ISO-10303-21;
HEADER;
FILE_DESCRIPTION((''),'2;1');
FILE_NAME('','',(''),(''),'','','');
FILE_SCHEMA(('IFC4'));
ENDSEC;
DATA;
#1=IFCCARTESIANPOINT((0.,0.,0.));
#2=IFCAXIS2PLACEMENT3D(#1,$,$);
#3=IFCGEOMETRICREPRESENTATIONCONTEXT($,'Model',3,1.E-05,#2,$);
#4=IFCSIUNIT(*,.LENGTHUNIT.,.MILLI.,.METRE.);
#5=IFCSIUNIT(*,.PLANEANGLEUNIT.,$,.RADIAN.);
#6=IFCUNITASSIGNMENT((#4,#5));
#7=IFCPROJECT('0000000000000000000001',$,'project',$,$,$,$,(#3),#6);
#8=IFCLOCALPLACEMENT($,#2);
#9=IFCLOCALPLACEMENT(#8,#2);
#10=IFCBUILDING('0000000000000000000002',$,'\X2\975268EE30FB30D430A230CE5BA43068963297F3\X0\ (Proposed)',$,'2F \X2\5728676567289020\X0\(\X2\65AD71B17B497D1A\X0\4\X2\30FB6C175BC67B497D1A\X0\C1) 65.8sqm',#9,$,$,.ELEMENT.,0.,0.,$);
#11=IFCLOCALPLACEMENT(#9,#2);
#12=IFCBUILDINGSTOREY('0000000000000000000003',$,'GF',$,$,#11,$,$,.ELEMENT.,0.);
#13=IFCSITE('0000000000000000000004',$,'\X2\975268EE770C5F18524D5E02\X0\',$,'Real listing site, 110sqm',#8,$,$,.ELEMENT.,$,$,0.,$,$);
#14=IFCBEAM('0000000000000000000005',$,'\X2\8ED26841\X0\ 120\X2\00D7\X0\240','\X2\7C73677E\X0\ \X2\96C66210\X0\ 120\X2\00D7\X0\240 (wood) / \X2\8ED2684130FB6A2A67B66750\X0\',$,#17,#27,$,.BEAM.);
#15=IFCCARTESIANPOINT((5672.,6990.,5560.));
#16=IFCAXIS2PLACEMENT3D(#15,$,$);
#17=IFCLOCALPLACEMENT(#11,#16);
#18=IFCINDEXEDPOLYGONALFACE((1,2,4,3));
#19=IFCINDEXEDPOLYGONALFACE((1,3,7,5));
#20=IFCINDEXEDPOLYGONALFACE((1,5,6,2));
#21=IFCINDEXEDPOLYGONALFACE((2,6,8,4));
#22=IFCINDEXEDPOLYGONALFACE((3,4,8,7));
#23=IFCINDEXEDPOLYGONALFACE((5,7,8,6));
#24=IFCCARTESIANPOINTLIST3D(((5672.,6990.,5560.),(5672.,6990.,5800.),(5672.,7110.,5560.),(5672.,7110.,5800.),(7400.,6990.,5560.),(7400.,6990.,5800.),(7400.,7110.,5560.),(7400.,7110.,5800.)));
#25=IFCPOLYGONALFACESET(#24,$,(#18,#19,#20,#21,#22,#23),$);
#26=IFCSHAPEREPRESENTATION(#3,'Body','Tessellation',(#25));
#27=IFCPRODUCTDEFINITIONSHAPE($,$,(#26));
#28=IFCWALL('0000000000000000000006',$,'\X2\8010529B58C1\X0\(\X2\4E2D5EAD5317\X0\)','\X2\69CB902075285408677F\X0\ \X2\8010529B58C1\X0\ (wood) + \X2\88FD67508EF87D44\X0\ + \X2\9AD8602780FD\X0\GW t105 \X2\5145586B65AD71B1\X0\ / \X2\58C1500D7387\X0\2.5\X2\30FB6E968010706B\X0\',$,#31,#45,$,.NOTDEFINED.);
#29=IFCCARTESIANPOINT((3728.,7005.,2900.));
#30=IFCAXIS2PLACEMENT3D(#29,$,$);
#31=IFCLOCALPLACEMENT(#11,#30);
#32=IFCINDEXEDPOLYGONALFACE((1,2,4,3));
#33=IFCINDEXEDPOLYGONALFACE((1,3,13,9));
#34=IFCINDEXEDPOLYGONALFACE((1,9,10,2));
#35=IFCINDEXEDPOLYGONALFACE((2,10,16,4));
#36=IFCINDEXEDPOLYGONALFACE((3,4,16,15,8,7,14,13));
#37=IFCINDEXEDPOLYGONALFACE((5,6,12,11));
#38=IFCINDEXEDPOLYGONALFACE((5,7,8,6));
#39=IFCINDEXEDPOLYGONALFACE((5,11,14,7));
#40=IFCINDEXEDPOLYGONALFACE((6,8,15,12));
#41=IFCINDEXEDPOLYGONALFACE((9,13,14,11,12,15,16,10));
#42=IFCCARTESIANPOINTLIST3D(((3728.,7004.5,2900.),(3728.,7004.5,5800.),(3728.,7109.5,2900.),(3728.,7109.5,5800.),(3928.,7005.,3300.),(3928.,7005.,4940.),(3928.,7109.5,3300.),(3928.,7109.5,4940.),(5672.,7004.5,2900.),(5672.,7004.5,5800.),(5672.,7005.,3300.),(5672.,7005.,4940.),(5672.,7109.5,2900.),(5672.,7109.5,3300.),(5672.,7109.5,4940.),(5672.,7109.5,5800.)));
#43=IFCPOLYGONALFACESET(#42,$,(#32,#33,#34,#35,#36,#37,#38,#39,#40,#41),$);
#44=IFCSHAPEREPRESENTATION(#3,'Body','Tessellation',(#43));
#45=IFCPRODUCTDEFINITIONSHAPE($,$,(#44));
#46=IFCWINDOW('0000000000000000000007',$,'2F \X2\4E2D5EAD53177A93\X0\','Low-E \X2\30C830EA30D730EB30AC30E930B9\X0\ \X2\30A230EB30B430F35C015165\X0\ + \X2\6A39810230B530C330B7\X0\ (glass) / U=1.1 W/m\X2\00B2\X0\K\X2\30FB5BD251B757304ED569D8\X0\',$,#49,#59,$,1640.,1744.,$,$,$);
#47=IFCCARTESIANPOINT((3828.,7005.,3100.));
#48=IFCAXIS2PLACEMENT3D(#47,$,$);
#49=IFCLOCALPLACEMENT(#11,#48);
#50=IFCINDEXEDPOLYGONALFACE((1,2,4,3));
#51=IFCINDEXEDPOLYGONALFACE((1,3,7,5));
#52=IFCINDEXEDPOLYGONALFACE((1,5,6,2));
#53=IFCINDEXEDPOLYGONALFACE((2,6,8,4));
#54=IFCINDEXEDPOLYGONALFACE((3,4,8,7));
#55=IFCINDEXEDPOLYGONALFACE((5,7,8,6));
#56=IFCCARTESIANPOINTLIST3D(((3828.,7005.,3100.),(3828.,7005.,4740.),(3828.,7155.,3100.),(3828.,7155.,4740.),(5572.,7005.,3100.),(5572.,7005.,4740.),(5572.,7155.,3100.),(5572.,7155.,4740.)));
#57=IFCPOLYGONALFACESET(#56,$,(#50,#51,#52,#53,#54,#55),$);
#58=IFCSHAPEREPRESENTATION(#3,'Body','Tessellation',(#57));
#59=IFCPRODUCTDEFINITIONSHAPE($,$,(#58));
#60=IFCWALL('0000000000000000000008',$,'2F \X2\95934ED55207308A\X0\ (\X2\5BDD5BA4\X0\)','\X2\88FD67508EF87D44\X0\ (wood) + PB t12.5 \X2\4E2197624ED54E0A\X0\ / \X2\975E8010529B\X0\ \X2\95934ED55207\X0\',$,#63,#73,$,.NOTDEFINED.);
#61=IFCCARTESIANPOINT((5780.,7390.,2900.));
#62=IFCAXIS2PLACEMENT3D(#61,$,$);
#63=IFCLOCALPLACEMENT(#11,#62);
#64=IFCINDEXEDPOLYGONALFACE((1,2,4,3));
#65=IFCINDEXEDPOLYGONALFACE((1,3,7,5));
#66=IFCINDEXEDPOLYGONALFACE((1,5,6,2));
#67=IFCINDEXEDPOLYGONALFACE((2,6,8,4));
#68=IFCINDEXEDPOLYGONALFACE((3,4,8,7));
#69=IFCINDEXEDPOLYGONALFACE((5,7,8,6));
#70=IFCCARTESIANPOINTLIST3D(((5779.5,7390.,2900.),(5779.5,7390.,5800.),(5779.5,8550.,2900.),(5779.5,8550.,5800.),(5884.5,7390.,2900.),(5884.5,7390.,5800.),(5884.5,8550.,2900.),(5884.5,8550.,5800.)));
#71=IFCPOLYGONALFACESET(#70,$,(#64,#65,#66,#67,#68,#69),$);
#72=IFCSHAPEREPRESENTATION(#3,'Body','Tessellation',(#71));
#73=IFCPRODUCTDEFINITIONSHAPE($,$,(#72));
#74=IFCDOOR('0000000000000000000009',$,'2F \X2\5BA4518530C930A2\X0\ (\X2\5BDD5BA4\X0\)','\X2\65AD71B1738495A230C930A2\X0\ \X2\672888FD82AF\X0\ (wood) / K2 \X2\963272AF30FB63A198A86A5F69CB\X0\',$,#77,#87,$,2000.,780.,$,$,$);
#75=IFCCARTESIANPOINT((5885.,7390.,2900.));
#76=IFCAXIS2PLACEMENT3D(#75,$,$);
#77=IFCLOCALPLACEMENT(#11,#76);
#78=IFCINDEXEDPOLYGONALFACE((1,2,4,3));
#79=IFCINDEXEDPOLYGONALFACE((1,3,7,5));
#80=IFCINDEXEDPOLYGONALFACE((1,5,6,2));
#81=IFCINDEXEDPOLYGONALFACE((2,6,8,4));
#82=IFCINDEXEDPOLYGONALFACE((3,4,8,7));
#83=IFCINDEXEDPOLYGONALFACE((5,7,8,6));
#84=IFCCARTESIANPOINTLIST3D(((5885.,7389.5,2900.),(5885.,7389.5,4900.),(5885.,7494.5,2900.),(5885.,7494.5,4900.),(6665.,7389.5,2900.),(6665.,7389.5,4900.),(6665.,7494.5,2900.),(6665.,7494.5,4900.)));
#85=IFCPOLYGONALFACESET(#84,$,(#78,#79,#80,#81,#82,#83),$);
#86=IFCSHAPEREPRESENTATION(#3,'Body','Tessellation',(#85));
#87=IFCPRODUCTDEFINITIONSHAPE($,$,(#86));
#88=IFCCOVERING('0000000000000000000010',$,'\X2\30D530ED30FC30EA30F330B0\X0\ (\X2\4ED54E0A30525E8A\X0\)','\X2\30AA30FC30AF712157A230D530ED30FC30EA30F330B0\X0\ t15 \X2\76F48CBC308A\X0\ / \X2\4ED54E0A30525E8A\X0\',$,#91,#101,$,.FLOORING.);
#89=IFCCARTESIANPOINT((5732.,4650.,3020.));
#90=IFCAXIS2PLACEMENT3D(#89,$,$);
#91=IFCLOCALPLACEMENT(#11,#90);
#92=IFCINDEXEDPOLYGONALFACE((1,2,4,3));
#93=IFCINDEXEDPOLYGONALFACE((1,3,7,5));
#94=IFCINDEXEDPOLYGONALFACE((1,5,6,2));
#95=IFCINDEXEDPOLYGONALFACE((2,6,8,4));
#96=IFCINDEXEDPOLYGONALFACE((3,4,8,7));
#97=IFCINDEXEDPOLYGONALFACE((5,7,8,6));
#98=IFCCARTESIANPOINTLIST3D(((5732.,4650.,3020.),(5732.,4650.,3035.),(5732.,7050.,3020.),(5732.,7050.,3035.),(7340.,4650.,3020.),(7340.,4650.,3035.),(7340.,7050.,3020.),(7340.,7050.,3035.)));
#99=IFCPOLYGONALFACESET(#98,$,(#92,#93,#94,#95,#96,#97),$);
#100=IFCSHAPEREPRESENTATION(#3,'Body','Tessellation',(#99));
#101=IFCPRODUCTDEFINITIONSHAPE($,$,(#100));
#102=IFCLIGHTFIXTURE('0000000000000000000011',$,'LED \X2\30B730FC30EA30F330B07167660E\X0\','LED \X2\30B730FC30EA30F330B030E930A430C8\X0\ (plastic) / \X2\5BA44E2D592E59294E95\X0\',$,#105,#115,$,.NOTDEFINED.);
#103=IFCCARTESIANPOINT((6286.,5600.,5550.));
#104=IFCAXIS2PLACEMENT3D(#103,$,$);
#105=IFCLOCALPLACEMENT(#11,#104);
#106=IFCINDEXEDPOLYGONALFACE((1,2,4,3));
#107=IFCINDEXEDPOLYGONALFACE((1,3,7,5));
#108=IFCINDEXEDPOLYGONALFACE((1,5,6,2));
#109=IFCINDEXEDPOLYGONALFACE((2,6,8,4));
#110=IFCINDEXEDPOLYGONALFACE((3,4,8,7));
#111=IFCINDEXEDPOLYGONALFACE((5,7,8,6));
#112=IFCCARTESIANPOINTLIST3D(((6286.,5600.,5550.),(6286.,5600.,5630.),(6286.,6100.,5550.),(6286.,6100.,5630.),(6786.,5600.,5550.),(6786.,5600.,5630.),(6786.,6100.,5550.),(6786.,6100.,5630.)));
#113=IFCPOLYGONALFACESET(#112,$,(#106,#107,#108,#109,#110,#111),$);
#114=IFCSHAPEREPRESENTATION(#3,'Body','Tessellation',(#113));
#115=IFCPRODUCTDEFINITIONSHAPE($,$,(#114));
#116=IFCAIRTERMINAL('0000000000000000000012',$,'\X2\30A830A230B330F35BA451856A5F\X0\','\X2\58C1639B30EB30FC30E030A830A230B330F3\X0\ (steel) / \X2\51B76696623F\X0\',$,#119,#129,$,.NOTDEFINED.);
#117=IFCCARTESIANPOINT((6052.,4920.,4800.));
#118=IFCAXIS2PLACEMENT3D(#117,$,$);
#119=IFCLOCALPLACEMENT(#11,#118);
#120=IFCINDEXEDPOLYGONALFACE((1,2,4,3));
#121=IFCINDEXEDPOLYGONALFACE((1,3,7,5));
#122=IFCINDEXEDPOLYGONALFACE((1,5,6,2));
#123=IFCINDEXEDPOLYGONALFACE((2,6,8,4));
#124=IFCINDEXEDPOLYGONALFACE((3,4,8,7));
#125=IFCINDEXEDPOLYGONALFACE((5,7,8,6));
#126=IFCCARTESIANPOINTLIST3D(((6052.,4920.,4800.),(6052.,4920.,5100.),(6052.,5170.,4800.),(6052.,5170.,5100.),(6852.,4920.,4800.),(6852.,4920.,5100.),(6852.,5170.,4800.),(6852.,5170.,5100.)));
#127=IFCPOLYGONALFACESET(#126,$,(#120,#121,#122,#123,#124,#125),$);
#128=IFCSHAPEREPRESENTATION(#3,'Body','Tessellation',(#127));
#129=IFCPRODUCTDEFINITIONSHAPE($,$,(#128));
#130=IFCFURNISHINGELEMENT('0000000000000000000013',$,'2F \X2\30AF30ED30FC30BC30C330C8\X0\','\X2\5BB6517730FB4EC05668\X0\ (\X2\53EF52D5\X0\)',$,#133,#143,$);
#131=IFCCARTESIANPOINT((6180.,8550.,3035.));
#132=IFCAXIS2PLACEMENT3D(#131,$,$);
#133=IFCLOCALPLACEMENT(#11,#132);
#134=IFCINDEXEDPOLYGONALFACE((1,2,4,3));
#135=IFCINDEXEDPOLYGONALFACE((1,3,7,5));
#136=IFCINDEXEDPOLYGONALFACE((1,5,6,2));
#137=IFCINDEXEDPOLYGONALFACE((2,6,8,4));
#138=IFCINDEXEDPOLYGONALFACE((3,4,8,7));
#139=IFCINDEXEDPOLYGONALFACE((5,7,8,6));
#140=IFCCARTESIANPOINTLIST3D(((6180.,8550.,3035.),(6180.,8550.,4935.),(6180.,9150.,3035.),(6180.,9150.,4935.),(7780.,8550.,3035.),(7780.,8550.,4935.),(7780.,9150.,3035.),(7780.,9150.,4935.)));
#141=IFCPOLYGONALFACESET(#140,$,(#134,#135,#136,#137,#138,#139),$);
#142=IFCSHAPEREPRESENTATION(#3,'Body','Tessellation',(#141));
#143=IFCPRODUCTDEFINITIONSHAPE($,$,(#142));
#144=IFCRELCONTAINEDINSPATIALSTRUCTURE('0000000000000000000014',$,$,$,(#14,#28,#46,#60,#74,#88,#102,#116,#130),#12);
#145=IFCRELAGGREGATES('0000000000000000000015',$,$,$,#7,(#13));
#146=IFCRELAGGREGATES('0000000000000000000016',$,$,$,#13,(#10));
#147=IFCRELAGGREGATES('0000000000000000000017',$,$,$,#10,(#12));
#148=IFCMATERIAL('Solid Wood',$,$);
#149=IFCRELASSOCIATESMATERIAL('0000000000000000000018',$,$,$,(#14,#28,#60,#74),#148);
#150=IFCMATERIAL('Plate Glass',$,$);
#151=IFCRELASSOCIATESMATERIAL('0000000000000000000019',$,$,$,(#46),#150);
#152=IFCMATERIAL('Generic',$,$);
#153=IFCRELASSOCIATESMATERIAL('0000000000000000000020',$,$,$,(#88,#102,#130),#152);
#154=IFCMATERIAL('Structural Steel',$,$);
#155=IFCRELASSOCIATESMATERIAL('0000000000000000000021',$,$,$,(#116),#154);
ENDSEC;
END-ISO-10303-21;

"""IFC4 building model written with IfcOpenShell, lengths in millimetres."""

from ifc_helpers import new_model, si_unit, frame, frame_2d, origin, place, context, project, spatial, rectangle, extrude, material, element, fill, save


model = new_model("IFC4")

# Units and contexts
model_context = context("Model", 3, precision=1e-05, world=origin())
ifc_project = project(units=[si_unit("LENGTHUNIT", "METRE", prefix="MILLI"), si_unit("PLANEANGLEUNIT", "RADIAN")], contexts=[model_context])

# Site, building, storey
site_placement = place(None, origin())
site = spatial("IfcSite", under=ifc_project, at=site_placement, Name="青森県弘前市", ObjectType="Real listing site, 110sqm", CompositionType="ELEMENT", RefElevation=0.0)
building_placement = place(site_placement, origin())
building = spatial("IfcBuilding", under=site, at=building_placement, Name="青森・ピアノ室と防音 (Proposed)", ObjectType="2F 在来木造(断熱等級4・気密等級C1) 65.8sqm", CompositionType="ELEMENT", ElevationOfRefHeight=0.0, ElevationOfTerrain=0.0)
storey_placement = place(building_placement, origin())
storey = spatial("IfcBuildingStorey", under=building, at=storey_placement, Name="GF", CompositionType="ELEMENT", Elevation=0.0)

# Shared definitions
ifc_material_1 = material(Name="Solid Wood")

# Beam
beam_1_placement = place(storey_placement, frame((5672.0, 6990.0, 5560.0)))
element("IfcBeam", 1, at=beam_1_placement, inside=storey, material=ifc_material_1, Name="軒桁 120×240", Description="米松 集成 120×240 (wood) / 軒桁・横架材", PredefinedType="BEAM", context=model_context, shape_type="SweptSolid", body=[
    extrude(rectangle(XDim=1728.0, YDim=120.0, at=frame_2d((864.0, 60.0))), frame((5672.0, 6990.0, 5560.0)), (0.0, 0.0, 1.0), 240.0),
])

# Wall, opening, window
wall_1_placement = place(storey_placement, frame((3728.0, 7005.0, 2900.0)))
wall_1 = element("IfcWall", 2, at=wall_1_placement, inside=storey, material=ifc_material_1, Name="耐力壁(中庭北)", Description="構造用合板 耐力壁 (wood) + 製材軸組 + 高性能GW t105 充填断熱 / 壁倍率2.5・準耐火", PredefinedType="NOTDEFINED", context=model_context, shape_type="SweptSolid", body=[
    extrude(rectangle(XDim=1944.0, YDim=105.0, at=frame_2d((972.0, 52.0))), frame((3728.0, 7005.0, 2900.0)), (0.0, 0.0, 1.0), 2900.0),
])
opening_placement = place(storey_placement, frame((3828.0, 7005.0, 3100.0)))
opening = element("IfcOpeningElement", 3, at=opening_placement, cuts=wall_1, PredefinedType="NOTDEFINED", context=model_context, shape_type="SweptSolid", body=[
    extrude(rectangle(XDim=1744.0, YDim=150.0, at=frame_2d((872.0, 75.0))), frame((3828.0, 7005.0, 3100.0)), (0.0, 0.0, 1.0), 1640.0),
])
ifc_material_2 = material(Name="Plate Glass")
window_placement = place(storey_placement, frame((3828.0, 7005.0, 3100.0)))
window = element("IfcWindow", 4, at=window_placement, inside=storey, material=ifc_material_2, Name="2F 中庭北窓", Description="Low-E トリプルガラス アルゴン封入 + 樹脂サッシ (glass) / U=1.1 W/m²K・寒冷地仕様", OverallHeight=1640.0, OverallWidth=1744.0, context=model_context, shape_type="SweptSolid", body=[
    extrude(rectangle(XDim=1744.0, YDim=150.0, at=frame_2d((872.0, 75.0))), frame((3828.0, 7005.0, 3100.0)), (0.0, 0.0, 1.0), 1640.0),
])
fill(opening, window)

# Wall
wall_2_placement = place(storey_placement, frame((5780.0, 7390.0, 2900.0)))
element("IfcWall", 5, at=wall_2_placement, inside=storey, material=ifc_material_1, Name="2F 間仕切り (寝室)", Description="製材軸組 (wood) + PB t12.5 両面仕上 / 非耐力 間仕切", PredefinedType="NOTDEFINED", context=model_context, shape_type="SweptSolid", body=[
    extrude(rectangle(XDim=105.0, YDim=1160.0, at=frame_2d((52.0, 580.0))), frame((5780.0, 7390.0, 2900.0)), (0.0, 0.0, 1.0), 2900.0),
])

# Door
door_placement = place(storey_placement, frame((5885.0, 7390.0, 2900.0)))
element("IfcDoor", 6, at=door_placement, inside=storey, material=ifc_material_1, Name="2F 室内ドア (寝室)", Description="断熱玄関ドア 木製芯 (wood) / K2 防犯・採風機構", OverallHeight=2000.0, OverallWidth=780.0, context=model_context, shape_type="SweptSolid", body=[
    extrude(rectangle(XDim=780.0, YDim=105.0, at=frame_2d((390.0, 52.0))), frame((5885.0, 7390.0, 2900.0)), (0.0, 0.0, 1.0), 2000.0),
])

# Covering
ifc_material_3 = material(Name="Generic")
covering_placement = place(storey_placement, frame((5732.0, 4650.0, 3020.0)))
element("IfcCovering", 7, at=covering_placement, inside=storey, material=ifc_material_3, Name="フローリング (仕上げ床)", Description="オーク無垢フローリング t15 直貼り / 仕上げ床", PredefinedType="FLOORING", context=model_context, shape_type="SweptSolid", body=[
    extrude(rectangle(XDim=1608.0, YDim=2400.0, at=frame_2d((804.0, 1200.0))), frame((5732.0, 4650.0, 3020.0)), (0.0, 0.0, 1.0), 15.0),
])

# Light fixture
light_fixture_placement = place(storey_placement, frame((6286.0, 5600.0, 5550.0)))
element("IfcLightFixture", 8, at=light_fixture_placement, inside=storey, material=ifc_material_3, Name="LED シーリング照明", Description="LED シーリングライト (plastic) / 室中央天井", PredefinedType="NOTDEFINED", context=model_context, shape_type="SweptSolid", body=[
    extrude(rectangle(XDim=500.0, YDim=500.0, at=frame_2d((250.0, 250.0))), frame((6286.0, 5600.0, 5550.0)), (0.0, 0.0, 1.0), 80.0),
])

# Air terminal
ifc_material_4 = material(Name="Structural Steel")
air_terminal_placement = place(storey_placement, frame((6052.0, 4920.0, 4800.0)))
element("IfcAirTerminal", 9, at=air_terminal_placement, inside=storey, material=ifc_material_4, Name="エアコン室内機", Description="壁掛ルームエアコン (steel) / 冷暖房", PredefinedType="NOTDEFINED", context=model_context, shape_type="SweptSolid", body=[
    extrude(rectangle(XDim=800.0, YDim=250.0, at=frame_2d((400.0, 125.0))), frame((6052.0, 4920.0, 4800.0)), (0.0, 0.0, 1.0), 300.0),
])

# Furnishing element
furnishing_placement = place(storey_placement, frame((6180.0, 8550.0, 3035.0)))
element("IfcFurnishingElement", 10, at=furnishing_placement, inside=storey, material=ifc_material_3, Name="2F クローゼット", Description="家具・什器 (可動)", context=model_context, shape_type="SweptSolid", body=[
    extrude(rectangle(XDim=1600.0, YDim=600.0, at=frame_2d((800.0, 300.0))), frame((6180.0, 8550.0, 3035.0)), (0.0, 0.0, 1.0), 1900.0),
])

save(model, "model.ifc")
